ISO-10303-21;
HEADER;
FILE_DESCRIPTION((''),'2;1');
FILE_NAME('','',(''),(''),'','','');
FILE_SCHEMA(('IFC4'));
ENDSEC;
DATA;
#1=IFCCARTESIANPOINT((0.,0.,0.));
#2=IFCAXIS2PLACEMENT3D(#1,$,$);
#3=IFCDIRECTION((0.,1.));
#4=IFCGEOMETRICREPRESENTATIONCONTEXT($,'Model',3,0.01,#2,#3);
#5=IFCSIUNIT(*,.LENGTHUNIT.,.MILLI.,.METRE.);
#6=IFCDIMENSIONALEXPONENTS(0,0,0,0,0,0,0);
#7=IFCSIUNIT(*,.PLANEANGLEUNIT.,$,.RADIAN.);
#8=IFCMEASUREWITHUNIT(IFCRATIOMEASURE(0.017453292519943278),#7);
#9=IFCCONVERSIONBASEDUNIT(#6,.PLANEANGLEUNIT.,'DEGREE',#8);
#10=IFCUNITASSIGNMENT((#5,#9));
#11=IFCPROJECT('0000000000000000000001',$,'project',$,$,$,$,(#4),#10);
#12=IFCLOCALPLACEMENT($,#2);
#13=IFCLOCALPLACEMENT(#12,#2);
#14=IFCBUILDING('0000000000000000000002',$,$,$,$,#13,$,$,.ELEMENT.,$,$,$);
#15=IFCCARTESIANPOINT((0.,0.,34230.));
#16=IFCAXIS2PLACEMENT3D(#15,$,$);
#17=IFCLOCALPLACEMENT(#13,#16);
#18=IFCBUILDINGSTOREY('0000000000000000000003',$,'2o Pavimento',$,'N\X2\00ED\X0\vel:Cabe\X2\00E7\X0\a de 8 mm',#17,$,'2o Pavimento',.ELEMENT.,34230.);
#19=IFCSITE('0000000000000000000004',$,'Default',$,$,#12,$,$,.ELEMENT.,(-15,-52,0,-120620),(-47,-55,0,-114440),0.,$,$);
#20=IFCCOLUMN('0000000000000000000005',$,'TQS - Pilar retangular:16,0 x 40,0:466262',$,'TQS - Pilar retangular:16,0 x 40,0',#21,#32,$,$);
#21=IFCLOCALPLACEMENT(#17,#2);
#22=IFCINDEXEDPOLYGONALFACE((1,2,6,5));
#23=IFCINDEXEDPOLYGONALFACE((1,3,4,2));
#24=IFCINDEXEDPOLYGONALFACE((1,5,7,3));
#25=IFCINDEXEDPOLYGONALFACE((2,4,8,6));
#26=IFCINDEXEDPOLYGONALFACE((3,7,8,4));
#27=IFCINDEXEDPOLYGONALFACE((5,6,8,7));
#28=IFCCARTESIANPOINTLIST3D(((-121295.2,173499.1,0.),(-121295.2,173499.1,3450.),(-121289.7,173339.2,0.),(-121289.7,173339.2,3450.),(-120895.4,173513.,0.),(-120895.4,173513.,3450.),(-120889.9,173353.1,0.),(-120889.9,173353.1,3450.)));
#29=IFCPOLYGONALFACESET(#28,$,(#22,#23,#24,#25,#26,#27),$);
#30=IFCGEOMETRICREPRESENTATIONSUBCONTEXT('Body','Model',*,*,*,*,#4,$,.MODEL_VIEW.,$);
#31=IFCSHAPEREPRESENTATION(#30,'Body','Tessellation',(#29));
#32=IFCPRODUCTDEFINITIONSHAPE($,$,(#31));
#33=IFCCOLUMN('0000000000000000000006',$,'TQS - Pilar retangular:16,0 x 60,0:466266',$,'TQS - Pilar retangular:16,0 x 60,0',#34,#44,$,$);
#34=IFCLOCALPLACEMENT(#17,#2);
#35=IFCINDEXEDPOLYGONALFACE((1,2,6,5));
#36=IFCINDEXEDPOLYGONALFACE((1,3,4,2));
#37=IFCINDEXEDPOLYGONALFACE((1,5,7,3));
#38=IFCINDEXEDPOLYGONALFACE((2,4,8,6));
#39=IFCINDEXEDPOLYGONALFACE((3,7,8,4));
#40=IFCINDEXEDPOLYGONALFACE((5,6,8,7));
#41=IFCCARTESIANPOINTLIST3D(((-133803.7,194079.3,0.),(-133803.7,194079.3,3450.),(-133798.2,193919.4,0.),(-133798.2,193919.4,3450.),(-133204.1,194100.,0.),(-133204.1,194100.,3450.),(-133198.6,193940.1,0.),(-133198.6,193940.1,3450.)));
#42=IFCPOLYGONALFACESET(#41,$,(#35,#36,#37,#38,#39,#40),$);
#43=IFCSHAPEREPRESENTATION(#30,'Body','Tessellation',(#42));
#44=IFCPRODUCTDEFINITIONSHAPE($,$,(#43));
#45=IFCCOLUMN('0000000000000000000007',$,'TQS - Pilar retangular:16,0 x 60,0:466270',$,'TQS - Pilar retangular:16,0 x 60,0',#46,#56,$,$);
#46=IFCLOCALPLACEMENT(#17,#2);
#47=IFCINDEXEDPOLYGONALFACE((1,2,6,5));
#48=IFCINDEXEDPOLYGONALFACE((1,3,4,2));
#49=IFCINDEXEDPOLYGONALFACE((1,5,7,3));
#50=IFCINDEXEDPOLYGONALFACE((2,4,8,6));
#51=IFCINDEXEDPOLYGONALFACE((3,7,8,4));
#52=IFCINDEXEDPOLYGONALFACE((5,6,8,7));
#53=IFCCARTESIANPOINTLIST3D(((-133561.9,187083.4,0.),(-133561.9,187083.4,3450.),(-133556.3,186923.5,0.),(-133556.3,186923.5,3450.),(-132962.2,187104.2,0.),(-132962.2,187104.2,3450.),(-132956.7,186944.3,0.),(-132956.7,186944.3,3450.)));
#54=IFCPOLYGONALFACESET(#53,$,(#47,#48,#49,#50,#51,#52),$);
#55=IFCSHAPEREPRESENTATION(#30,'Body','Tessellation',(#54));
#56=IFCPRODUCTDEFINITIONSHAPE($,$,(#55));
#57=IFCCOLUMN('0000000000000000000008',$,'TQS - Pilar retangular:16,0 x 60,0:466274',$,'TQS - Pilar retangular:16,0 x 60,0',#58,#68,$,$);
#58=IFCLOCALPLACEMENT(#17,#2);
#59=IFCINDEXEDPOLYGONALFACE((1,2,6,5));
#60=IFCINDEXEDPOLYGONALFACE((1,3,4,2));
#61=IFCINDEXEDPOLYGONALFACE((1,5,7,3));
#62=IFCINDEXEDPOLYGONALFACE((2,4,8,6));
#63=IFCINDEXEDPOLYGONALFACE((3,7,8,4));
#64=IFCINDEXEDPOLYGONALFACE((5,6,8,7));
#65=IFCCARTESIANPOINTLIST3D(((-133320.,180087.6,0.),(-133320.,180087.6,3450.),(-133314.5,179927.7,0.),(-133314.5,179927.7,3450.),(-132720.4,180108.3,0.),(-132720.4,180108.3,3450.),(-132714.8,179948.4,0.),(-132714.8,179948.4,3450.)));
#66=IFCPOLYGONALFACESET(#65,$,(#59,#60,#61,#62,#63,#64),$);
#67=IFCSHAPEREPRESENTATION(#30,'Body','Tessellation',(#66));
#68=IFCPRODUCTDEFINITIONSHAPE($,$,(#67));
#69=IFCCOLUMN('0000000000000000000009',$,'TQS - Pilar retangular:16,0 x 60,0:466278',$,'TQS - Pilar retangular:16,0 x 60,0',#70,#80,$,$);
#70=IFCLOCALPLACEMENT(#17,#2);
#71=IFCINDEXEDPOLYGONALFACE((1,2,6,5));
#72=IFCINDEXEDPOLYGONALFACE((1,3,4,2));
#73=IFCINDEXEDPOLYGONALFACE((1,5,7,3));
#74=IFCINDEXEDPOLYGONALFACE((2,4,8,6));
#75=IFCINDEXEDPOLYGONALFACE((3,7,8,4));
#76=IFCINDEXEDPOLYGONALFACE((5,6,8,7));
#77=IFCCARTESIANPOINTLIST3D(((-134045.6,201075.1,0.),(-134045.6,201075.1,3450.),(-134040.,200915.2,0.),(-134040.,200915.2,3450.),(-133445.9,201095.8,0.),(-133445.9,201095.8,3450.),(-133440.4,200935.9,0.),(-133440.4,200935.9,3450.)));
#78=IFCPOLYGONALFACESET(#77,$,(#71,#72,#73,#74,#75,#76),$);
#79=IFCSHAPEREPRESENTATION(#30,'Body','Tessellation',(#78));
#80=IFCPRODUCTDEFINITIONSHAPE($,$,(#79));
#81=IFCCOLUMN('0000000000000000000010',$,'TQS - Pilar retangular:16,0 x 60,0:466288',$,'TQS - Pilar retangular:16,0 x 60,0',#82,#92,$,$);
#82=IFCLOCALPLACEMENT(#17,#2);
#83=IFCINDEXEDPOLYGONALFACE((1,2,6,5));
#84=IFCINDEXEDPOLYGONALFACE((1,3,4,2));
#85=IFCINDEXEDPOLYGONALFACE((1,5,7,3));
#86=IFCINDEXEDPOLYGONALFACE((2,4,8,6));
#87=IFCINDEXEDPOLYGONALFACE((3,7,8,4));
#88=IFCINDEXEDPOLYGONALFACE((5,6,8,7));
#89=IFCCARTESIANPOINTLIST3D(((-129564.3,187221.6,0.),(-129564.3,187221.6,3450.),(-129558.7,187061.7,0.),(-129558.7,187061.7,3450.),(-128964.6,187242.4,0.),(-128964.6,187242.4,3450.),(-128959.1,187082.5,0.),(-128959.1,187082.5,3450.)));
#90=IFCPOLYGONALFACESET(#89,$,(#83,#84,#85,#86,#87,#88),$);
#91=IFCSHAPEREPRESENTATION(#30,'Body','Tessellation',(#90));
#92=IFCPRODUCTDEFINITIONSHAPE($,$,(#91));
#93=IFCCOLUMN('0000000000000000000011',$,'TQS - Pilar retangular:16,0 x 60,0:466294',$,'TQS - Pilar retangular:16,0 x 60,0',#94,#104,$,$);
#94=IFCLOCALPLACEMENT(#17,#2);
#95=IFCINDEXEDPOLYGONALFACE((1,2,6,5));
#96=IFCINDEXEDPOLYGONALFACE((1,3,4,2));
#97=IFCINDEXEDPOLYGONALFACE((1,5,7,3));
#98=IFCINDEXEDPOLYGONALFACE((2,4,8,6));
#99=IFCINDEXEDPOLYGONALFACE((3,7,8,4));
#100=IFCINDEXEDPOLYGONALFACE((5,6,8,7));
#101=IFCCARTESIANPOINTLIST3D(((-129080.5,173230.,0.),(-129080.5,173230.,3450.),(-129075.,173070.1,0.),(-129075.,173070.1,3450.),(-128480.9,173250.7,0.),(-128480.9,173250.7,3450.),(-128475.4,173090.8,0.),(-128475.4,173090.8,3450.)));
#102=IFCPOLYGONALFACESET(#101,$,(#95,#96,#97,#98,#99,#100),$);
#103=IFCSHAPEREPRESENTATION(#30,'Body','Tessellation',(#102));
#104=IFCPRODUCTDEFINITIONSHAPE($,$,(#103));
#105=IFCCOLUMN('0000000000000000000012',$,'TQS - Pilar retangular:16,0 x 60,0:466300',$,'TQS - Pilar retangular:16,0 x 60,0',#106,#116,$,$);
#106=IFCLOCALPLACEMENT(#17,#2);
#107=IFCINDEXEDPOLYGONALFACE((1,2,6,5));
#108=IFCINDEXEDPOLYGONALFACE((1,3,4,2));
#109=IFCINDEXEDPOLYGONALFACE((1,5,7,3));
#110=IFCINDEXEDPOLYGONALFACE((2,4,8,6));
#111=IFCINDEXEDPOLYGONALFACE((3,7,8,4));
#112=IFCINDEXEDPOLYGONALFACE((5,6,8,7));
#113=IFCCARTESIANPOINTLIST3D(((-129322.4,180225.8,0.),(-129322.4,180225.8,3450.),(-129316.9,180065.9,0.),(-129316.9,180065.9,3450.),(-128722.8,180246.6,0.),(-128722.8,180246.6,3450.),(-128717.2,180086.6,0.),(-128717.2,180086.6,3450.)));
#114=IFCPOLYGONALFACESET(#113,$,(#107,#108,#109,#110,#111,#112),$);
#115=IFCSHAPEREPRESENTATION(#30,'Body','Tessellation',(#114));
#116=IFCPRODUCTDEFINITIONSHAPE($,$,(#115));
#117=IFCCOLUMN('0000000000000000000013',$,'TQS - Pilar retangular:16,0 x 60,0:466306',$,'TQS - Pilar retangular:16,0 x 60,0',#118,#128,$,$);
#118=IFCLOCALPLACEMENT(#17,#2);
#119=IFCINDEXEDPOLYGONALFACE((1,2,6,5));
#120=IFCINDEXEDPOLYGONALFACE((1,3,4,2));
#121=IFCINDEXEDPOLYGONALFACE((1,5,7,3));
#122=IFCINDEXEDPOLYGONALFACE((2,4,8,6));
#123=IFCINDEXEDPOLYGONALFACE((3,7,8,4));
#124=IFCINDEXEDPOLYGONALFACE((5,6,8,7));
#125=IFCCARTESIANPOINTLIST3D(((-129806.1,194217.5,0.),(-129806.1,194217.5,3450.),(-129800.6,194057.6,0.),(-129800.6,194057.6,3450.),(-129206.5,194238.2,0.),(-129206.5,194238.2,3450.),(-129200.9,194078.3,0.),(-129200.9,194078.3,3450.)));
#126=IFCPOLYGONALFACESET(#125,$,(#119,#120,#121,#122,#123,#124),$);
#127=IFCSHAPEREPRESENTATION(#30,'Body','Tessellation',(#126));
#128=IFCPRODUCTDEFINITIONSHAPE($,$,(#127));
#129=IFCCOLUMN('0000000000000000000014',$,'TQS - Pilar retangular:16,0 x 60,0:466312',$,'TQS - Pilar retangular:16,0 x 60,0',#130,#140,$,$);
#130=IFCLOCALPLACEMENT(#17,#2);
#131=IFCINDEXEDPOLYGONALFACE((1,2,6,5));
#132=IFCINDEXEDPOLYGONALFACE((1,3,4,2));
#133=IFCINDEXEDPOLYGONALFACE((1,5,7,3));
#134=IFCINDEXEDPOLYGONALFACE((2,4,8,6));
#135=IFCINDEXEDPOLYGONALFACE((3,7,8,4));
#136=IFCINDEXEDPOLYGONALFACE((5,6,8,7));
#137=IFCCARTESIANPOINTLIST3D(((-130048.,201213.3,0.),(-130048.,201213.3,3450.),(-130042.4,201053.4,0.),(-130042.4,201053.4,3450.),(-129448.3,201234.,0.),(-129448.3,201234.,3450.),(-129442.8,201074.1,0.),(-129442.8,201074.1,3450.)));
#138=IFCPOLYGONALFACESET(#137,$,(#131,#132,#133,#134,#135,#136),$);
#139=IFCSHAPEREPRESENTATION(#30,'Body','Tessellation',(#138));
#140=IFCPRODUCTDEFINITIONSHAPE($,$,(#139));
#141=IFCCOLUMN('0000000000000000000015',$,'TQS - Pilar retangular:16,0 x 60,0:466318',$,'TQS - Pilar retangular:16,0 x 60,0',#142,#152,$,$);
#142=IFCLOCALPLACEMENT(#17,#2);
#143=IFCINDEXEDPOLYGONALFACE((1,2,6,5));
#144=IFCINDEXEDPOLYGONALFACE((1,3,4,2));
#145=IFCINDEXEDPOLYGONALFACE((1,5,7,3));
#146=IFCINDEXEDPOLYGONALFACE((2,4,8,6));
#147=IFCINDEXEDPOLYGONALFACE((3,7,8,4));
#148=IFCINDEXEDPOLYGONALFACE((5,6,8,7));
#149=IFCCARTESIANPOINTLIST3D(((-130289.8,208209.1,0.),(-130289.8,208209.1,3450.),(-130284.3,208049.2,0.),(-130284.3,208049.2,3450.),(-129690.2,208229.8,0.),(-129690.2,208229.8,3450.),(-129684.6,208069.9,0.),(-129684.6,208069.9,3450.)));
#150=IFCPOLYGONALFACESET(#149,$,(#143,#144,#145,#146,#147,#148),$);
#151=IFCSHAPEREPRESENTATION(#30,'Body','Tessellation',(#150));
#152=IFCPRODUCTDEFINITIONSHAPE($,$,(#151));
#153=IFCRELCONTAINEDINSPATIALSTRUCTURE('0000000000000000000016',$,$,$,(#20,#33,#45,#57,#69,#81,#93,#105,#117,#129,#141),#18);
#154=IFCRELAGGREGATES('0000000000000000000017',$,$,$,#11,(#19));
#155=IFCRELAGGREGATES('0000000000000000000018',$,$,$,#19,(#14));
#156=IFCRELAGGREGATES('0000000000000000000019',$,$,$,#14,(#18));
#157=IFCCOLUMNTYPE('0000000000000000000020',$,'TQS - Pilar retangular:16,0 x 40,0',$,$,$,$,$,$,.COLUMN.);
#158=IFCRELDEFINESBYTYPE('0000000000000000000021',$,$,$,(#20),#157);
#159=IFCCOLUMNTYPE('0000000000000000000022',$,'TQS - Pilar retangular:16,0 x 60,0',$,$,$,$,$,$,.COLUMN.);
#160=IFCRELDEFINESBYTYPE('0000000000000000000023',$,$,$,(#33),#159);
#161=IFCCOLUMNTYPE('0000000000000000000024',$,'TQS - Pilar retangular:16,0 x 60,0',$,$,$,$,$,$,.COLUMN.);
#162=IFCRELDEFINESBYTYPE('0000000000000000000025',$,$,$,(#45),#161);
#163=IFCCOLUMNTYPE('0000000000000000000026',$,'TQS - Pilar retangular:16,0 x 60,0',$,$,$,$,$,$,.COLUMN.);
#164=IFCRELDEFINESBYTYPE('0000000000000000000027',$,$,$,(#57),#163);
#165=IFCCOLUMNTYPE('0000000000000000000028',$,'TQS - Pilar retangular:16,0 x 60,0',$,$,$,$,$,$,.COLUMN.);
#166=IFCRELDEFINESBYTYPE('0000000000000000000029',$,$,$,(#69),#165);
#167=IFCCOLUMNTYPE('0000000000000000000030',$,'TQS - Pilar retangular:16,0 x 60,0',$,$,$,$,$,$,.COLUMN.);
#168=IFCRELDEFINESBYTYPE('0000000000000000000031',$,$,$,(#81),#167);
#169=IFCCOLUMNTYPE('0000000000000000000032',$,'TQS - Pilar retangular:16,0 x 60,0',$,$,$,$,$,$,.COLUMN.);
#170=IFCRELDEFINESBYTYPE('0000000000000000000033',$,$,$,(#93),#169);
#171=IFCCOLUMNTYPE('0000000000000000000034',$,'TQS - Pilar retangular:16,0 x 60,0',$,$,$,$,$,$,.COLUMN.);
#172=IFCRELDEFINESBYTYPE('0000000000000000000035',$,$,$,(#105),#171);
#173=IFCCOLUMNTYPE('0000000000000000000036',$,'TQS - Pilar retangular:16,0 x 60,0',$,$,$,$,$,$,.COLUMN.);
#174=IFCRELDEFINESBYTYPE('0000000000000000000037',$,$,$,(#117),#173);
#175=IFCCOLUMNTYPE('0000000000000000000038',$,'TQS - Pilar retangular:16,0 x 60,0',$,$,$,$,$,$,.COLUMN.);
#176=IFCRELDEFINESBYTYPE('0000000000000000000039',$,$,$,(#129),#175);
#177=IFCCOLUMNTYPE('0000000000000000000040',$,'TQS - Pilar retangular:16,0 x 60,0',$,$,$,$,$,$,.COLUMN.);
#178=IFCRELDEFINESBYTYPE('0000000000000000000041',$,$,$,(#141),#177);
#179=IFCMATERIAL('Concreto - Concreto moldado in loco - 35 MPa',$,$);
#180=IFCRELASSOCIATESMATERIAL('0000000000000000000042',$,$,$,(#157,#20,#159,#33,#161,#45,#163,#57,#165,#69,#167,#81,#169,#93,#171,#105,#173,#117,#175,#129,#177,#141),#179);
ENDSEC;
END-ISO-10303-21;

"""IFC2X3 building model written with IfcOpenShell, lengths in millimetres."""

from ifc_helpers import new_model, entity, si_unit, converted_unit, direction, frame, origin, origin_2d_with_axis, place, context, subcontext, project, spatial, rectangle, extrude, source, transform, mapped, material, type_object, type_shapes, element, save


model = new_model("IFC2X3")

# Units and contexts
model_context = context("Model", 3, precision=0.01, world=origin(), true_north=direction((0.0, 1.0)))
body_context = subcontext(model_context, "Body", "Model", "MODEL_VIEW")
ifc_project = project(units=[si_unit("LENGTHUNIT", "METRE", prefix="MILLI"), converted_unit("PLANEANGLEUNIT", "DEGREE", entity("IfcRatioMeasure", 0.017453292519943278), si_unit("PLANEANGLEUNIT", "RADIAN"), dimensions=[0, 0, 0, 0, 0, 0, 0])], contexts=[model_context])

# Site, building, storey
site_placement = place(None, origin())
site = spatial("IfcSite", under=ifc_project, at=site_placement, Name="Default", CompositionType="ELEMENT", RefLatitude=(-15, -52, 0, -120620), RefLongitude=(-47, -55, 0, -114440), RefElevation=0.0)
building_placement = place(site_placement, origin())
building = spatial("IfcBuilding", under=site, at=building_placement, CompositionType="ELEMENT")
storey_placement = place(building_placement, frame((0.0, 0.0, 34230.0)))
storey = spatial("IfcBuildingStorey", under=building, at=storey_placement, Name="2o Pavimento", ObjectType="Nível:Cabeça de 8 mm", LongName="2o Pavimento", CompositionType="ELEMENT", Elevation=34230.0)

# Columns
ifc_material = material(Name="Concreto - Concreto moldado in loco - 35 MPa")
column_type_1 = type_object("IfcColumnType", Name="TQS - Pilar retangular:16,0 x 40,0", PredefinedType="COLUMN", material=ifc_material)
shared_shape_1 = source(origin(), body_context, "Body", "SweptSolid", [
    extrude(rectangle(XDim=400.0, YDim=160.0, at=origin_2d_with_axis()), frame((-121092.6, 173426.1, 34230.0), z_axis=(0.0, 0.0, 1.0), x_axis=(-0.999403, -0.034551, 0.0)), (0.0, 0.0, 1.0), 3450.0),
])
type_shapes(column_type_1, [shared_shape_1])
column_1_placement = place(storey_placement, frame((0.0, 0.0, -34230.0)))
element("IfcColumn", 1, at=column_1_placement, inside=storey, type_object=column_type_1, material=ifc_material, Name="TQS - Pilar retangular:16,0 x 40,0:466262", ObjectType="TQS - Pilar retangular:16,0 x 40,0", context=body_context, shape_type="MappedRepresentation", body=[
    mapped(shared_shape_1, transform((0.0, 0.0, 0.0), scale=1.0)),
])
column_type_2 = type_object("IfcColumnType", Name="TQS - Pilar retangular:16,0 x 60,0", PredefinedType="COLUMN", material=ifc_material)
shared_shape_2 = source(origin(), body_context, "Body", "SweptSolid", [
    extrude(rectangle(XDim=600.0, YDim=160.0, at=origin_2d_with_axis()), frame((-133501.1, 194009.7, 34230.0), z_axis=(0.0, 0.0, 1.0), x_axis=(-0.999403, -0.034551, 0.0)), (0.0, 0.0, 1.0), 3450.0),
])
type_shapes(column_type_2, [shared_shape_2])
column_2_placement = place(storey_placement, frame((0.0, 0.0, -34230.0)))
element("IfcColumn", 2, at=column_2_placement, inside=storey, type_object=column_type_2, material=ifc_material, Name="TQS - Pilar retangular:16,0 x 60,0:466266", ObjectType="TQS - Pilar retangular:16,0 x 60,0", context=body_context, shape_type="MappedRepresentation", body=[
    mapped(shared_shape_2, transform((0.0, 0.0, 0.0), scale=1.0)),
])
column_type_3 = type_object("IfcColumnType", Name="TQS - Pilar retangular:16,0 x 60,0", PredefinedType="COLUMN", material=ifc_material)
shared_shape_3 = source(origin(), body_context, "Body", "SweptSolid", [
    extrude(rectangle(XDim=600.0, YDim=160.0, at=origin_2d_with_axis()), frame((-133259.3, 187013.9, 34230.0), z_axis=(0.0, 0.0, 1.0), x_axis=(-0.999403, -0.034551, 0.0)), (0.0, 0.0, 1.0), 3450.0),
])
type_shapes(column_type_3, [shared_shape_3])
column_3_placement = place(storey_placement, frame((0.0, 0.0, -34230.0)))
element("IfcColumn", 3, at=column_3_placement, inside=storey, type_object=column_type_3, material=ifc_material, Name="TQS - Pilar retangular:16,0 x 60,0:466270", ObjectType="TQS - Pilar retangular:16,0 x 60,0", context=body_context, shape_type="MappedRepresentation", body=[
    mapped(shared_shape_3, transform((0.0, 0.0, 0.0), scale=1.0)),
])
column_type_4 = type_object("IfcColumnType", Name="TQS - Pilar retangular:16,0 x 60,0", PredefinedType="COLUMN", material=ifc_material)
shared_shape_4 = source(origin(), body_context, "Body", "SweptSolid", [
    extrude(rectangle(XDim=600.0, YDim=160.0, at=origin_2d_with_axis()), frame((-133017.4, 180018.0, 34230.0), z_axis=(0.0, 0.0, 1.0), x_axis=(-0.999403, -0.034551, 0.0)), (0.0, 0.0, 1.0), 3450.0),
])
type_shapes(column_type_4, [shared_shape_4])
column_4_placement = place(storey_placement, frame((0.0, 0.0, -34230.0)))
element("IfcColumn", 4, at=column_4_placement, inside=storey, type_object=column_type_4, material=ifc_material, Name="TQS - Pilar retangular:16,0 x 60,0:466274", ObjectType="TQS - Pilar retangular:16,0 x 60,0", context=body_context, shape_type="MappedRepresentation", body=[
    mapped(shared_shape_4, transform((0.0, 0.0, 0.0), scale=1.0)),
])
column_type_5 = type_object("IfcColumnType", Name="TQS - Pilar retangular:16,0 x 60,0", PredefinedType="COLUMN", material=ifc_material)
shared_shape_5 = source(origin(), body_context, "Body", "SweptSolid", [
    extrude(rectangle(XDim=600.0, YDim=160.0, at=origin_2d_with_axis()), frame((-133743.0, 201005.5, 34230.0), z_axis=(0.0, 0.0, 1.0), x_axis=(-0.999403, -0.034551, 0.0)), (0.0, 0.0, 1.0), 3450.0),
])
type_shapes(column_type_5, [shared_shape_5])
column_5_placement = place(storey_placement, frame((0.0, 0.0, -34230.0)))
element("IfcColumn", 5, at=column_5_placement, inside=storey, type_object=column_type_5, material=ifc_material, Name="TQS - Pilar retangular:16,0 x 60,0:466278", ObjectType="TQS - Pilar retangular:16,0 x 60,0", context=body_context, shape_type="MappedRepresentation", body=[
    mapped(shared_shape_5, transform((0.0, 0.0, 0.0), scale=1.0)),
])
column_type_6 = type_object("IfcColumnType", Name="TQS - Pilar retangular:16,0 x 60,0", PredefinedType="COLUMN", material=ifc_material)
shared_shape_6 = source(origin(), body_context, "Body", "SweptSolid", [
    extrude(rectangle(XDim=600.0, YDim=160.0, at=origin_2d_with_axis()), frame((-129261.7, 187152.1, 34230.0), z_axis=(0.0, 0.0, 1.0), x_axis=(-0.999403, -0.034551, 0.0)), (0.0, 0.0, 1.0), 3450.0),
])
type_shapes(column_type_6, [shared_shape_6])
column_6_placement = place(storey_placement, frame((0.0, 0.0, -34230.0)))
element("IfcColumn", 6, at=column_6_placement, inside=storey, type_object=column_type_6, material=ifc_material, Name="TQS - Pilar retangular:16,0 x 60,0:466288", ObjectType="TQS - Pilar retangular:16,0 x 60,0", context=body_context, shape_type="MappedRepresentation", body=[
    mapped(shared_shape_6, transform((0.0, 0.0, 0.0), scale=1.0)),
])
column_type_7 = type_object("IfcColumnType", Name="TQS - Pilar retangular:16,0 x 60,0", PredefinedType="COLUMN", material=ifc_material)
shared_shape_7 = source(origin(), body_context, "Body", "SweptSolid", [
    extrude(rectangle(XDim=600.0, YDim=160.0, at=origin_2d_with_axis()), frame((-128778.0, 173160.4, 34230.0), z_axis=(0.0, 0.0, 1.0), x_axis=(-0.999403, -0.034551, 0.0)), (0.0, 0.0, 1.0), 3450.0),
])
type_shapes(column_type_7, [shared_shape_7])
column_7_placement = place(storey_placement, frame((0.0, 0.0, -34230.0)))
element("IfcColumn", 7, at=column_7_placement, inside=storey, type_object=column_type_7, material=ifc_material, Name="TQS - Pilar retangular:16,0 x 60,0:466294", ObjectType="TQS - Pilar retangular:16,0 x 60,0", context=body_context, shape_type="MappedRepresentation", body=[
    mapped(shared_shape_7, transform((0.0, 0.0, 0.0), scale=1.0)),
])
column_type_8 = type_object("IfcColumnType", Name="TQS - Pilar retangular:16,0 x 60,0", PredefinedType="COLUMN", material=ifc_material)
shared_shape_8 = source(origin(), body_context, "Body", "SweptSolid", [
    extrude(rectangle(XDim=600.0, YDim=160.0, at=origin_2d_with_axis()), frame((-129019.8, 180156.2, 34230.0), z_axis=(0.0, 0.0, 1.0), x_axis=(-0.999403, -0.034551, 0.0)), (0.0, 0.0, 1.0), 3450.0),
])
type_shapes(column_type_8, [shared_shape_8])
column_8_placement = place(storey_placement, frame((0.0, 0.0, -34230.0)))
element("IfcColumn", 8, at=column_8_placement, inside=storey, type_object=column_type_8, material=ifc_material, Name="TQS - Pilar retangular:16,0 x 60,0:466300", ObjectType="TQS - Pilar retangular:16,0 x 60,0", context=body_context, shape_type="MappedRepresentation", body=[
    mapped(shared_shape_8, transform((0.0, 0.0, 0.0), scale=1.0)),
])
column_type_9 = type_object("IfcColumnType", Name="TQS - Pilar retangular:16,0 x 60,0", PredefinedType="COLUMN", material=ifc_material)
shared_shape_9 = source(origin(), body_context, "Body", "SweptSolid", [
    extrude(rectangle(XDim=600.0, YDim=160.0, at=origin_2d_with_axis()), frame((-129503.5, 194147.9, 34230.0), z_axis=(0.0, 0.0, 1.0), x_axis=(-0.999403, -0.034551, 0.0)), (0.0, 0.0, 1.0), 3450.0),
])
type_shapes(column_type_9, [shared_shape_9])
column_9_placement = place(storey_placement, frame((0.0, 0.0, -34230.0)))
element("IfcColumn", 9, at=column_9_placement, inside=storey, type_object=column_type_9, material=ifc_material, Name="TQS - Pilar retangular:16,0 x 60,0:466306", ObjectType="TQS - Pilar retangular:16,0 x 60,0", context=body_context, shape_type="MappedRepresentation", body=[
    mapped(shared_shape_9, transform((0.0, 0.0, 0.0), scale=1.0)),
])
column_type_10 = type_object("IfcColumnType", Name="TQS - Pilar retangular:16,0 x 60,0", PredefinedType="COLUMN", material=ifc_material)
shared_shape_10 = source(origin(), body_context, "Body", "SweptSolid", [
    extrude(rectangle(XDim=600.0, YDim=160.0, at=origin_2d_with_axis()), frame((-129745.4, 201143.7, 34230.0), z_axis=(0.0, 0.0, 1.0), x_axis=(-0.999403, -0.034551, 0.0)), (0.0, 0.0, 1.0), 3450.0),
])
type_shapes(column_type_10, [shared_shape_10])
column_10_placement = place(storey_placement, frame((0.0, 0.0, -34230.0)))
element("IfcColumn", 10, at=column_10_placement, inside=storey, type_object=column_type_10, material=ifc_material, Name="TQS - Pilar retangular:16,0 x 60,0:466312", ObjectType="TQS - Pilar retangular:16,0 x 60,0", context=body_context, shape_type="MappedRepresentation", body=[
    mapped(shared_shape_10, transform((0.0, 0.0, 0.0), scale=1.0)),
])
column_type_11 = type_object("IfcColumnType", Name="TQS - Pilar retangular:16,0 x 60,0", PredefinedType="COLUMN", material=ifc_material)
shared_shape_11 = source(origin(), body_context, "Body", "SweptSolid", [
    extrude(rectangle(XDim=600.0, YDim=160.0, at=origin_2d_with_axis()), frame((-129987.2, 208139.5, 34230.0), z_axis=(0.0, 0.0, 1.0), x_axis=(-0.999403, -0.034551, 0.0)), (0.0, 0.0, 1.0), 3450.0),
])
type_shapes(column_type_11, [shared_shape_11])
column_11_placement = place(storey_placement, frame((0.0, 0.0, -34230.0)))
element("IfcColumn", 11, at=column_11_placement, inside=storey, type_object=column_type_11, material=ifc_material, Name="TQS - Pilar retangular:16,0 x 60,0:466318", ObjectType="TQS - Pilar retangular:16,0 x 60,0", context=body_context, shape_type="MappedRepresentation", body=[
    mapped(shared_shape_11, transform((0.0, 0.0, 0.0), scale=1.0)),
])

save(model, "model.ifc")
